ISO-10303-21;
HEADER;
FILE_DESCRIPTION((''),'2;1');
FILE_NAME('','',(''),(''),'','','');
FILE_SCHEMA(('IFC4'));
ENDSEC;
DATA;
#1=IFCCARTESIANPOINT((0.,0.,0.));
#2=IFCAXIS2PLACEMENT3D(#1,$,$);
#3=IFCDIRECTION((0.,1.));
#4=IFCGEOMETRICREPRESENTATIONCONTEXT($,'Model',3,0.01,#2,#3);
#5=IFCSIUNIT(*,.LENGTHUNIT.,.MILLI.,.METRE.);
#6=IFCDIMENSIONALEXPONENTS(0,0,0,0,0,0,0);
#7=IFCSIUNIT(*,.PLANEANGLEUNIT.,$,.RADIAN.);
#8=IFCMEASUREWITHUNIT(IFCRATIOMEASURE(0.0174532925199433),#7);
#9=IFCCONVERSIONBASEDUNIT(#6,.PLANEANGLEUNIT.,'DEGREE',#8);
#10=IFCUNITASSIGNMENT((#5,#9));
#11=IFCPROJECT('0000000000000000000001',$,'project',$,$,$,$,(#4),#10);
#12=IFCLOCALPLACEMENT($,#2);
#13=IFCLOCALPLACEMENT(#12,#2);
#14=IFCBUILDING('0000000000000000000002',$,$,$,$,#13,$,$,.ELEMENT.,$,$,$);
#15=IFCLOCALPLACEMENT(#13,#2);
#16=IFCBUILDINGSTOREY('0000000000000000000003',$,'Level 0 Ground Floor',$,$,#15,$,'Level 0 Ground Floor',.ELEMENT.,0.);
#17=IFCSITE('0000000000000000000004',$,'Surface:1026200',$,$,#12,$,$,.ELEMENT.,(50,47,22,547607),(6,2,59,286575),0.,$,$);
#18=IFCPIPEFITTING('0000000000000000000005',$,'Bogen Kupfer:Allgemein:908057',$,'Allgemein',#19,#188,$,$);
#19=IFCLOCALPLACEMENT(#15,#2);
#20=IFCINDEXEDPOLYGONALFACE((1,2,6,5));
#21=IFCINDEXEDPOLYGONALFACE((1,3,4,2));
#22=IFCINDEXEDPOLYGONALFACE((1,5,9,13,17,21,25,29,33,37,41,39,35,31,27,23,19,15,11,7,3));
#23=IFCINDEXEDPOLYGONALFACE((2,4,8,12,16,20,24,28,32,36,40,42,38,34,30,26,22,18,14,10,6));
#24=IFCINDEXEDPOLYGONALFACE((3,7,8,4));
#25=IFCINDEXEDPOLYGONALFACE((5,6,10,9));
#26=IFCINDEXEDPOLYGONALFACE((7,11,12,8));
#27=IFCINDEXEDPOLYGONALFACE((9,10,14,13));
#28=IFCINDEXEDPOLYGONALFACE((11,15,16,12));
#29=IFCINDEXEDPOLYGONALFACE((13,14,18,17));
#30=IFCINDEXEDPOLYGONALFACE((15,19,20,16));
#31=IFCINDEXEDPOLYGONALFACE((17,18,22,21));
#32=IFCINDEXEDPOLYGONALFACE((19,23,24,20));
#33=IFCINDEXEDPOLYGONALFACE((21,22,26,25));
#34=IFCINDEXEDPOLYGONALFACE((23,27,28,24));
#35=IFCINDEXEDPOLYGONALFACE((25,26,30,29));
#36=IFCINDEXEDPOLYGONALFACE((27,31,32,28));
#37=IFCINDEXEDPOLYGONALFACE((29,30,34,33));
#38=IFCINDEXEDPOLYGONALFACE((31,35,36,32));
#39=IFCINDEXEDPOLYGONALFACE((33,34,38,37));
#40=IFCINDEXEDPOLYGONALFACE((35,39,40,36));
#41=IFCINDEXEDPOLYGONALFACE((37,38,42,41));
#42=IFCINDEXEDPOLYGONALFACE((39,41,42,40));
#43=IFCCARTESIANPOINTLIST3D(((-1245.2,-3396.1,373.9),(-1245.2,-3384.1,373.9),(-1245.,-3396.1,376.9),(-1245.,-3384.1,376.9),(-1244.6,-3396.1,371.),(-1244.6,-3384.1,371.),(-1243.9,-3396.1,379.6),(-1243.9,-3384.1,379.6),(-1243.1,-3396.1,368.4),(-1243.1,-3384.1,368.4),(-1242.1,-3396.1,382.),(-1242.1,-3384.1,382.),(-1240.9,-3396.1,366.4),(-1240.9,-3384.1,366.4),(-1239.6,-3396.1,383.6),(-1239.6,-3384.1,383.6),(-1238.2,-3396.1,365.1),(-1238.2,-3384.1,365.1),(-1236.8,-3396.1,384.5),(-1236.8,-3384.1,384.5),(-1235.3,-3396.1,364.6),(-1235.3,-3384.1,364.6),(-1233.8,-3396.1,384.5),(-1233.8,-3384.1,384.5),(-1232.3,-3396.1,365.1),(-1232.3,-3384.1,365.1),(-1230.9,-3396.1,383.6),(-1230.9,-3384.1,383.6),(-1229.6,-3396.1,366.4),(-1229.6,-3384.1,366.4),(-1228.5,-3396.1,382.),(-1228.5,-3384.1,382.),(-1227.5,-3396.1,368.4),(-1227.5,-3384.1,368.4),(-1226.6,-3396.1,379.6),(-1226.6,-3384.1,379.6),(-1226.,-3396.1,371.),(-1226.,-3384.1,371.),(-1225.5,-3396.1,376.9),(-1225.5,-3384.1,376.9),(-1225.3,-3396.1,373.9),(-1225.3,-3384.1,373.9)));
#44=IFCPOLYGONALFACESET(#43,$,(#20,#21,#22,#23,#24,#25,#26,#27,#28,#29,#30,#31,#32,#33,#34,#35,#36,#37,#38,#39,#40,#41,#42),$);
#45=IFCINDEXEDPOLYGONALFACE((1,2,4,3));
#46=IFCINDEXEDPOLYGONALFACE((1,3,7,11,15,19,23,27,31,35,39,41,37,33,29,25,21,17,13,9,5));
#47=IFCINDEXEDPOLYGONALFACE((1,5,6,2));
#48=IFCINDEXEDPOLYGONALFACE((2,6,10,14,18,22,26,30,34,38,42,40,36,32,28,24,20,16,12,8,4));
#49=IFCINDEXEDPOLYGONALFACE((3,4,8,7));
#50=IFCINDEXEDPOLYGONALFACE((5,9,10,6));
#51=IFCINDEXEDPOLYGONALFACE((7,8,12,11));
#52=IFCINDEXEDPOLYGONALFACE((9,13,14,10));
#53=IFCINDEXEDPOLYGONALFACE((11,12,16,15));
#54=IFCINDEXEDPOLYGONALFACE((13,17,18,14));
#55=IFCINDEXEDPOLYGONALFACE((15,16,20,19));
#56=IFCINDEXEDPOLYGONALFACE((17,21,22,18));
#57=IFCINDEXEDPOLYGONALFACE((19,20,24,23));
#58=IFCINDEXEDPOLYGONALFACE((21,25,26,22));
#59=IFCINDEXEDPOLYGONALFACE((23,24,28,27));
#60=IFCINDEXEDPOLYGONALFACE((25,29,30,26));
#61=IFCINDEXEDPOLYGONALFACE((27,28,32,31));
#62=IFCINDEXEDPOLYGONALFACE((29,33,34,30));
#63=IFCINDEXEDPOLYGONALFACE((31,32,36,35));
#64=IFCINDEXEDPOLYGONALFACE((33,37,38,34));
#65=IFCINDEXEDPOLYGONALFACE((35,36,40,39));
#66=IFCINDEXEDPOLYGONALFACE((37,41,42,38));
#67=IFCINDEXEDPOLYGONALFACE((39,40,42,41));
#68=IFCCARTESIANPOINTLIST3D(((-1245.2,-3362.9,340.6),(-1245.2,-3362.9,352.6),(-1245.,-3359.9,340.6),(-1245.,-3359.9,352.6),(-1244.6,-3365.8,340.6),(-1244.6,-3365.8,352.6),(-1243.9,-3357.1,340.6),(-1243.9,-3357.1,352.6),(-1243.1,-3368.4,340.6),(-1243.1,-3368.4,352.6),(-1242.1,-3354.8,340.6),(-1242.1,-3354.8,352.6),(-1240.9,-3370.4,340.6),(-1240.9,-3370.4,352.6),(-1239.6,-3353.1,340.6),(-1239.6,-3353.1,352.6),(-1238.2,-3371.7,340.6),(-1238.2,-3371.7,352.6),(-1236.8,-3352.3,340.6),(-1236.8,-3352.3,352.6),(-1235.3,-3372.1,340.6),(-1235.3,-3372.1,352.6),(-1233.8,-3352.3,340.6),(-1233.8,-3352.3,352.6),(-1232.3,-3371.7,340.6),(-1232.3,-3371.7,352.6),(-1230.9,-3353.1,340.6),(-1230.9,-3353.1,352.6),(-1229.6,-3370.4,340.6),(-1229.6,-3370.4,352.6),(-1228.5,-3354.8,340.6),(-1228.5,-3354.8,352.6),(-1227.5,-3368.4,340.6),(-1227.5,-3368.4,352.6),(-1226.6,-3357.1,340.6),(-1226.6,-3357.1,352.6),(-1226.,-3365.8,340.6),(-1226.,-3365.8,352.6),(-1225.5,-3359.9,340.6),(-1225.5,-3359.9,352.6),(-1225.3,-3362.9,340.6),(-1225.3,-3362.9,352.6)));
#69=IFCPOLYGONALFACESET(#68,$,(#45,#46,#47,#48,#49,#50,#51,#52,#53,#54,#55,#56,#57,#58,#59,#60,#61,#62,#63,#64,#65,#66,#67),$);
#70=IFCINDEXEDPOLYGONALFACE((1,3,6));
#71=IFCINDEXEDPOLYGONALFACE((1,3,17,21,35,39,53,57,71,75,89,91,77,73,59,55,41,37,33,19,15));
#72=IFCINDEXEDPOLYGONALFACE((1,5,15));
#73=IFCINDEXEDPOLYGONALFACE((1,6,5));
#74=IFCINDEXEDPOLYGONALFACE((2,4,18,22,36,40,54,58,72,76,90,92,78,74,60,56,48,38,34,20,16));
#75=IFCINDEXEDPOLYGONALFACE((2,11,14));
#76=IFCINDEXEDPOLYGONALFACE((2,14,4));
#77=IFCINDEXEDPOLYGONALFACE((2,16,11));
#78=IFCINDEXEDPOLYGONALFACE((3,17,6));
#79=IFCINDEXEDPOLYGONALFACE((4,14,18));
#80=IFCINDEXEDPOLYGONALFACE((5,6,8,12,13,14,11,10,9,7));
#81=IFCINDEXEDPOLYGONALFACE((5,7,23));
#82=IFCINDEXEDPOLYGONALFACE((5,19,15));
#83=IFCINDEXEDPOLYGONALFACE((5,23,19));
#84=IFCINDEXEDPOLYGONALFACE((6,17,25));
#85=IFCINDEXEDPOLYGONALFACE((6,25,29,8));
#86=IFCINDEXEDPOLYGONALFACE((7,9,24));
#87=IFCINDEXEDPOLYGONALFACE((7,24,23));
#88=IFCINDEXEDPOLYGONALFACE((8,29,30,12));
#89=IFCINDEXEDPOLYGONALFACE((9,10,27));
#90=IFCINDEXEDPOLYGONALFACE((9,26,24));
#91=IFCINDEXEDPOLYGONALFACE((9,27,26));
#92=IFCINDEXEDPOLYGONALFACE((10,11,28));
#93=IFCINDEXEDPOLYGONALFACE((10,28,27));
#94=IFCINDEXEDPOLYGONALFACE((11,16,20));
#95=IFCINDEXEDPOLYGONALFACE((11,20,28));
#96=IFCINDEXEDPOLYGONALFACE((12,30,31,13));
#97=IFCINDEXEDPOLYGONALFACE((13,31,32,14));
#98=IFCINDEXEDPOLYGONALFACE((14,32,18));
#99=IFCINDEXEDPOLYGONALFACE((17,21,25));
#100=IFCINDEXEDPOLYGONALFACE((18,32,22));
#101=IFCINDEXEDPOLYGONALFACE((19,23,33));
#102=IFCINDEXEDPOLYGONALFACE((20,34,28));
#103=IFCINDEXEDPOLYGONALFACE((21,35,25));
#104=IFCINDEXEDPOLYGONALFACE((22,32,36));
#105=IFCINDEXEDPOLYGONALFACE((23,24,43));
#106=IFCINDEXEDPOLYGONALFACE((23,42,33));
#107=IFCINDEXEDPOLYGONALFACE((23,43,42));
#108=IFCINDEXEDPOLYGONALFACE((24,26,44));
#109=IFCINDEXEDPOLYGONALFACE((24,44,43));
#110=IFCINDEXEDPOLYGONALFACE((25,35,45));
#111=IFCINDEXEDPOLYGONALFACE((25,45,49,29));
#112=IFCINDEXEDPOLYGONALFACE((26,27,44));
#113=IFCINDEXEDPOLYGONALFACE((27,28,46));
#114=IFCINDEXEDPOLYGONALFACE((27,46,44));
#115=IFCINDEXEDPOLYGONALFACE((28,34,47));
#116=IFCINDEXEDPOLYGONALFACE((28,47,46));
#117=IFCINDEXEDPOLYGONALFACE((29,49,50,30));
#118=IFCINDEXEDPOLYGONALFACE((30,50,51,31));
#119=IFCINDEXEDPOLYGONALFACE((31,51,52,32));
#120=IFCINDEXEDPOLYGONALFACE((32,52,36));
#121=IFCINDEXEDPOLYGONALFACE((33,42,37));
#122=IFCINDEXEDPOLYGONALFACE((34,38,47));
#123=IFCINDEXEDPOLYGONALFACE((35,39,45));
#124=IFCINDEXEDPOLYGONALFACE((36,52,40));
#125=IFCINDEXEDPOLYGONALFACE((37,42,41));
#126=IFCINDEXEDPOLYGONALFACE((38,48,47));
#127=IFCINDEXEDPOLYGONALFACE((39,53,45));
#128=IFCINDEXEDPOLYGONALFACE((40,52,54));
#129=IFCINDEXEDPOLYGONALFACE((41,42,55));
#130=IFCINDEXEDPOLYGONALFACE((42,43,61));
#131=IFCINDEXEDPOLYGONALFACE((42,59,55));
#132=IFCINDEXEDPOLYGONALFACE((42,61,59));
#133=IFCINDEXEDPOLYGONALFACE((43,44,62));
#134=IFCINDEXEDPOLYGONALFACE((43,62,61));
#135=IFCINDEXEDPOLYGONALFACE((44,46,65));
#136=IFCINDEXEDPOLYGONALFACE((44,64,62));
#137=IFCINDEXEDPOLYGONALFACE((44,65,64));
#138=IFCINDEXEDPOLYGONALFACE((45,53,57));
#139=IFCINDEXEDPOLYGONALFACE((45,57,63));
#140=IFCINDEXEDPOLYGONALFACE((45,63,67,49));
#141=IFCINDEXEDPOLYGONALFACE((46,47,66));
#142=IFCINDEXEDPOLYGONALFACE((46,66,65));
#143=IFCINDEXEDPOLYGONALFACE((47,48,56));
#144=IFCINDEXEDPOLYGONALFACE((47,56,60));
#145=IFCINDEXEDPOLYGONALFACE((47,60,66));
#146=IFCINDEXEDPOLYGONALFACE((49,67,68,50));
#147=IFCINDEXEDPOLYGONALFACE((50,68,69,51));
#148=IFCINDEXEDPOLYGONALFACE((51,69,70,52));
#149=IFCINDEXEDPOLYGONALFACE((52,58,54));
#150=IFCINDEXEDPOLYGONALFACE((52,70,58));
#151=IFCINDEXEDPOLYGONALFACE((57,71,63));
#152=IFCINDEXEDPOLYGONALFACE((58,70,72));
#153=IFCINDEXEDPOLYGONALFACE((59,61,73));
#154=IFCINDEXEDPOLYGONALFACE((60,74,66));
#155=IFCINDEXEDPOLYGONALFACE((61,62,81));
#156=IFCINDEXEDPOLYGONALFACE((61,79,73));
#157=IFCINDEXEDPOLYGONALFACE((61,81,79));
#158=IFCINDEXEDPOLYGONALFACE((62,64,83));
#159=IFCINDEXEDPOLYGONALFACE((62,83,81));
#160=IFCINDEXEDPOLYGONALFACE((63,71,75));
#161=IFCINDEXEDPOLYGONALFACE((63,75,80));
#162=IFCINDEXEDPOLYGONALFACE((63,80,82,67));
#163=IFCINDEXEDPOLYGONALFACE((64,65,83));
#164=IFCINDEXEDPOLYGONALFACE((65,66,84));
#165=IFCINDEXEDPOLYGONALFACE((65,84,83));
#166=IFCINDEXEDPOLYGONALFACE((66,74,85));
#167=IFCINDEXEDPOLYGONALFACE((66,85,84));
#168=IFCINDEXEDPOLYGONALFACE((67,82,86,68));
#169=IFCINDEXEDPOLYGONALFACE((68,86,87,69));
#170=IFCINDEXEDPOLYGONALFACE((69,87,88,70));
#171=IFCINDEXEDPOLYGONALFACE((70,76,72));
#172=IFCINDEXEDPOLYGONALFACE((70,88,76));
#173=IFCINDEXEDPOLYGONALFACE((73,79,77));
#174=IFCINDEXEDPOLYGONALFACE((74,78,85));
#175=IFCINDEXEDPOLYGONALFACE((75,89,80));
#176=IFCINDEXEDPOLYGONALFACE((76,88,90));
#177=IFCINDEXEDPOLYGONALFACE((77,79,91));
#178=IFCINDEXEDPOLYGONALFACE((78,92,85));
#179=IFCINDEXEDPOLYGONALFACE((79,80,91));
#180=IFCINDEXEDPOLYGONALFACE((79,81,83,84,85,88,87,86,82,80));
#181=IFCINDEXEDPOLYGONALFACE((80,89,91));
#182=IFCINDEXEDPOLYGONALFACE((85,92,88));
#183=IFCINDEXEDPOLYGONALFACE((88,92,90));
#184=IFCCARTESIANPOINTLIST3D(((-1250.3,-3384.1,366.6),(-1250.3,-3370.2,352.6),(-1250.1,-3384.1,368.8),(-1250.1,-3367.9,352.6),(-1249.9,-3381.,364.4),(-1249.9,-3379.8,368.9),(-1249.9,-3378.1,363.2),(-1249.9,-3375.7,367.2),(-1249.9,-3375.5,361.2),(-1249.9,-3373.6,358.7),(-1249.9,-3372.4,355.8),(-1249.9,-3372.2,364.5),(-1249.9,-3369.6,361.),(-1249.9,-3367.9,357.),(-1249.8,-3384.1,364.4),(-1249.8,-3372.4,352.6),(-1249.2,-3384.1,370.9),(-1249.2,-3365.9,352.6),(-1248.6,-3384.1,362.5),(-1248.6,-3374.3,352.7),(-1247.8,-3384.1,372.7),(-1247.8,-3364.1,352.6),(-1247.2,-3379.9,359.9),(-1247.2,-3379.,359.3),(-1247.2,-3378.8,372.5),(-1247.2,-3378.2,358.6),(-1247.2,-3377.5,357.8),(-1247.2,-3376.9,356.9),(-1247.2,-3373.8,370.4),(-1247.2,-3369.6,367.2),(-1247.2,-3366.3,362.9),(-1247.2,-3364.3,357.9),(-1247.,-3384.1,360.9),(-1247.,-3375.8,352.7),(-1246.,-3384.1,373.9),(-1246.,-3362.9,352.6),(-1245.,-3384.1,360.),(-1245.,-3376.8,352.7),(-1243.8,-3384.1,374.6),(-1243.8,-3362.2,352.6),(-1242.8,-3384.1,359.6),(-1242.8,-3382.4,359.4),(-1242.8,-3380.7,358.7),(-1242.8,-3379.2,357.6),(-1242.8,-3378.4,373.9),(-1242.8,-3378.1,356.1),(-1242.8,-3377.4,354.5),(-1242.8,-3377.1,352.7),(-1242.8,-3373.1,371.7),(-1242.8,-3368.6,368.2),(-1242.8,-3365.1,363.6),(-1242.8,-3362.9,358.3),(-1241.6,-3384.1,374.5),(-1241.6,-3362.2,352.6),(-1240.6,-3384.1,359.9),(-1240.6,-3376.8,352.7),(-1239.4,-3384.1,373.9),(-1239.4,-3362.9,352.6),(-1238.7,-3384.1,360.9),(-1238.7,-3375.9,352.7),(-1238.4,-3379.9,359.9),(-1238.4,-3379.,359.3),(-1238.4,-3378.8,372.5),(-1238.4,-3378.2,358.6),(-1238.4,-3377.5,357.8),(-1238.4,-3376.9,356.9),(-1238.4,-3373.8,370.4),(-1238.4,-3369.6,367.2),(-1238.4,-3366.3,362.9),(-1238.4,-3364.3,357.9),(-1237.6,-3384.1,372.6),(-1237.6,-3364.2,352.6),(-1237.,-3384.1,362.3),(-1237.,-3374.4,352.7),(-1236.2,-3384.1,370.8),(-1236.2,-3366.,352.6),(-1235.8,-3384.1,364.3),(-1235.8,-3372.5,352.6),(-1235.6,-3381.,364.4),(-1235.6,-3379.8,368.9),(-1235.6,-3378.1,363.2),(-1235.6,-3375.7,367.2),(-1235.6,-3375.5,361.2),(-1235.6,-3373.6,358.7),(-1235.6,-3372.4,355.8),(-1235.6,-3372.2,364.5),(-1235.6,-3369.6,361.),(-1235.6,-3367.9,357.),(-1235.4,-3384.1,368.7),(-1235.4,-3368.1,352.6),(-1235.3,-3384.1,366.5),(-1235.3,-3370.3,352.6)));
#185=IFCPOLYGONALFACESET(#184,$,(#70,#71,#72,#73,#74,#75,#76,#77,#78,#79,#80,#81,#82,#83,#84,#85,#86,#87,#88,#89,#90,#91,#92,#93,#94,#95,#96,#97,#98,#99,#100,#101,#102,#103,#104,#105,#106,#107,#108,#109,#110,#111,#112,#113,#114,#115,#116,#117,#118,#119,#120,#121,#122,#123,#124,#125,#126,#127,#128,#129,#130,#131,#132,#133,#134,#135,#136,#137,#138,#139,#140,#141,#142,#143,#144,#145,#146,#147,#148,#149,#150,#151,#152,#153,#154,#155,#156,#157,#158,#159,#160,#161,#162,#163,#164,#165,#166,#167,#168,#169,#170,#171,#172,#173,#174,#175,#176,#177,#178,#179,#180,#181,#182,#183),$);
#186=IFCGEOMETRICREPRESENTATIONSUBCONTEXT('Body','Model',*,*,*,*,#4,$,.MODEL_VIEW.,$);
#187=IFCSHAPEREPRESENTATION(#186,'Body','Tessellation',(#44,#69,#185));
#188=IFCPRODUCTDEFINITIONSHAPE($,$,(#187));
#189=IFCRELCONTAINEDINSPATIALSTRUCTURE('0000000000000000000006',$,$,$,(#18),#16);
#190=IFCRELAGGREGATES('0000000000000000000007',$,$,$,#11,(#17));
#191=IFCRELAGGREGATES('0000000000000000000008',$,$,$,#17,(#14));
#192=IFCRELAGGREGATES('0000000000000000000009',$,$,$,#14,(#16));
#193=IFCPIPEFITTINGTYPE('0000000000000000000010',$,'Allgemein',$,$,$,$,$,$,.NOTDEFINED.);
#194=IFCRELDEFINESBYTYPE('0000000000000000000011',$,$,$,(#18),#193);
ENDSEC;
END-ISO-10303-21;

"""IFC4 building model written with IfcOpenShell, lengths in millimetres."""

from ifc_helpers import new_model, entity, si_unit, converted_unit, direction, frame, frame_2d, origin, place, context, subcontext, project, spatial, circle, extrude, source, transform, mapped, type_object, type_shapes, element, save


model = new_model("IFC4")

# Units and contexts
model_context = context("Model", 3, precision=0.01, world=origin(), true_north=direction((0.0, 1.0)))
body_context = subcontext(model_context, "Body", "Model", "MODEL_VIEW")
ifc_project = project(units=[si_unit("LENGTHUNIT", "METRE", prefix="MILLI"), converted_unit("PLANEANGLEUNIT", "DEGREE", entity("IfcRatioMeasure", 0.0174532925199433), si_unit("PLANEANGLEUNIT", "RADIAN"), dimensions=[0, 0, 0, 0, 0, 0, 0])], contexts=[model_context])

# Site, building, storey
site_placement = place(None, origin())
site = spatial("IfcSite", under=ifc_project, at=site_placement, Name="Surface:1026200", CompositionType="ELEMENT", RefLatitude=(50, 47, 22, 547607), RefLongitude=(6, 2, 59, 286575), RefElevation=0.0)
building_placement = place(site_placement, origin())
building = spatial("IfcBuilding", under=site, at=building_placement, CompositionType="ELEMENT")
storey_placement = place(building_placement, origin())
storey = spatial("IfcBuildingStorey", under=building, at=storey_placement, Name="Level 0 Ground Floor", LongName="Level 0 Ground Floor", CompositionType="ELEMENT", Elevation=0.0)

# Pipe fitting
pipe_fitting_type = type_object("IfcPipeFittingType", Name="Allgemein", PredefinedType="NOTDEFINED")
ifc_direction = entity("IfcDirection", [0.0, 0.0, -1.0])
trimmed_curve = entity("IfcTrimmedCurve", entity("IfcCircle", entity("IfcAxis2Placement2D", entity("IfcCartesianPoint", [-14.5, 0.0]), entity("IfcDirection", [0.0, 1.0])), 14.5), [entity("IfcParameterValue", 270.0)], [entity("IfcParameterValue", 0.0)], True, "PARAMETER")
shared_shape_1 = source(origin(), body_context, "Body", "SolidModel", [
    extrude(circle(Radius=10.0, at=frame_2d((0.0, 0.0), x_axis=(1.0, 0.0))), frame((0.0, 22.0, 0.0), z_axis=(0.0, 1.0, 0.0), x_axis=(-1.0, 0.0, 0.0)), (0.0, 0.0, 1.0), 12.0),
    extrude(circle(Radius=10.0, at=frame_2d((0.0, 0.0), x_axis=(1.0, 0.0))), frame((-34.0, 0.0, 0.0), z_axis=(1.0, 0.0, 0.0), x_axis=(0.0, 1.0, 0.0)), (0.0, 0.0, 1.0), 12.0),
    entity("IfcSurfaceCurveSweptAreaSolid", entity("IfcCircleProfileDef", "AREA", None, entity("IfcAxis2Placement2D", entity("IfcCartesianPoint", [0.0, 7.5]), entity("IfcDirection", [1.0, 0.0])), 7.5), entity("IfcAxis2Placement3D", entity("IfcCartesianPoint", [-7.5, 22.0, 0.0]), ifc_direction, entity("IfcDirection", [1.0, 0.0, 0.0])), trimmed_curve, 0.0, 90.0, entity("IfcSurfaceOfLinearExtrusion", entity("IfcArbitraryOpenProfileDef", "CURVE", None, trimmed_curve), entity("IfcAxis2Placement3D", entity("IfcCartesianPoint", [0.0, 0.0, -304.8])), ifc_direction, 1.0)),
])
type_shapes(pipe_fitting_type, [shared_shape_1])
for number, where, z_axis, x_axis, name in (
    (1, (-1235.3, -3362.1, 374.6), (1.0, 0.0, 0.0), (0.0, 0.0, 1.0), "Bogen Kupfer:Allgemein:908057"),
):
    element("IfcPipeFitting", number, at=place(storey_placement, frame(where, z_axis=z_axis, x_axis=x_axis)), inside=storey, type_object=pipe_fitting_type, Name=name, ObjectType="Allgemein", context=body_context, shape_type="MappedRepresentation", body=[
        mapped(shared_shape_1, transform((0.0, 0.0, 0.0), scale=1.0)),
    ])

save(model, "model.ifc")
